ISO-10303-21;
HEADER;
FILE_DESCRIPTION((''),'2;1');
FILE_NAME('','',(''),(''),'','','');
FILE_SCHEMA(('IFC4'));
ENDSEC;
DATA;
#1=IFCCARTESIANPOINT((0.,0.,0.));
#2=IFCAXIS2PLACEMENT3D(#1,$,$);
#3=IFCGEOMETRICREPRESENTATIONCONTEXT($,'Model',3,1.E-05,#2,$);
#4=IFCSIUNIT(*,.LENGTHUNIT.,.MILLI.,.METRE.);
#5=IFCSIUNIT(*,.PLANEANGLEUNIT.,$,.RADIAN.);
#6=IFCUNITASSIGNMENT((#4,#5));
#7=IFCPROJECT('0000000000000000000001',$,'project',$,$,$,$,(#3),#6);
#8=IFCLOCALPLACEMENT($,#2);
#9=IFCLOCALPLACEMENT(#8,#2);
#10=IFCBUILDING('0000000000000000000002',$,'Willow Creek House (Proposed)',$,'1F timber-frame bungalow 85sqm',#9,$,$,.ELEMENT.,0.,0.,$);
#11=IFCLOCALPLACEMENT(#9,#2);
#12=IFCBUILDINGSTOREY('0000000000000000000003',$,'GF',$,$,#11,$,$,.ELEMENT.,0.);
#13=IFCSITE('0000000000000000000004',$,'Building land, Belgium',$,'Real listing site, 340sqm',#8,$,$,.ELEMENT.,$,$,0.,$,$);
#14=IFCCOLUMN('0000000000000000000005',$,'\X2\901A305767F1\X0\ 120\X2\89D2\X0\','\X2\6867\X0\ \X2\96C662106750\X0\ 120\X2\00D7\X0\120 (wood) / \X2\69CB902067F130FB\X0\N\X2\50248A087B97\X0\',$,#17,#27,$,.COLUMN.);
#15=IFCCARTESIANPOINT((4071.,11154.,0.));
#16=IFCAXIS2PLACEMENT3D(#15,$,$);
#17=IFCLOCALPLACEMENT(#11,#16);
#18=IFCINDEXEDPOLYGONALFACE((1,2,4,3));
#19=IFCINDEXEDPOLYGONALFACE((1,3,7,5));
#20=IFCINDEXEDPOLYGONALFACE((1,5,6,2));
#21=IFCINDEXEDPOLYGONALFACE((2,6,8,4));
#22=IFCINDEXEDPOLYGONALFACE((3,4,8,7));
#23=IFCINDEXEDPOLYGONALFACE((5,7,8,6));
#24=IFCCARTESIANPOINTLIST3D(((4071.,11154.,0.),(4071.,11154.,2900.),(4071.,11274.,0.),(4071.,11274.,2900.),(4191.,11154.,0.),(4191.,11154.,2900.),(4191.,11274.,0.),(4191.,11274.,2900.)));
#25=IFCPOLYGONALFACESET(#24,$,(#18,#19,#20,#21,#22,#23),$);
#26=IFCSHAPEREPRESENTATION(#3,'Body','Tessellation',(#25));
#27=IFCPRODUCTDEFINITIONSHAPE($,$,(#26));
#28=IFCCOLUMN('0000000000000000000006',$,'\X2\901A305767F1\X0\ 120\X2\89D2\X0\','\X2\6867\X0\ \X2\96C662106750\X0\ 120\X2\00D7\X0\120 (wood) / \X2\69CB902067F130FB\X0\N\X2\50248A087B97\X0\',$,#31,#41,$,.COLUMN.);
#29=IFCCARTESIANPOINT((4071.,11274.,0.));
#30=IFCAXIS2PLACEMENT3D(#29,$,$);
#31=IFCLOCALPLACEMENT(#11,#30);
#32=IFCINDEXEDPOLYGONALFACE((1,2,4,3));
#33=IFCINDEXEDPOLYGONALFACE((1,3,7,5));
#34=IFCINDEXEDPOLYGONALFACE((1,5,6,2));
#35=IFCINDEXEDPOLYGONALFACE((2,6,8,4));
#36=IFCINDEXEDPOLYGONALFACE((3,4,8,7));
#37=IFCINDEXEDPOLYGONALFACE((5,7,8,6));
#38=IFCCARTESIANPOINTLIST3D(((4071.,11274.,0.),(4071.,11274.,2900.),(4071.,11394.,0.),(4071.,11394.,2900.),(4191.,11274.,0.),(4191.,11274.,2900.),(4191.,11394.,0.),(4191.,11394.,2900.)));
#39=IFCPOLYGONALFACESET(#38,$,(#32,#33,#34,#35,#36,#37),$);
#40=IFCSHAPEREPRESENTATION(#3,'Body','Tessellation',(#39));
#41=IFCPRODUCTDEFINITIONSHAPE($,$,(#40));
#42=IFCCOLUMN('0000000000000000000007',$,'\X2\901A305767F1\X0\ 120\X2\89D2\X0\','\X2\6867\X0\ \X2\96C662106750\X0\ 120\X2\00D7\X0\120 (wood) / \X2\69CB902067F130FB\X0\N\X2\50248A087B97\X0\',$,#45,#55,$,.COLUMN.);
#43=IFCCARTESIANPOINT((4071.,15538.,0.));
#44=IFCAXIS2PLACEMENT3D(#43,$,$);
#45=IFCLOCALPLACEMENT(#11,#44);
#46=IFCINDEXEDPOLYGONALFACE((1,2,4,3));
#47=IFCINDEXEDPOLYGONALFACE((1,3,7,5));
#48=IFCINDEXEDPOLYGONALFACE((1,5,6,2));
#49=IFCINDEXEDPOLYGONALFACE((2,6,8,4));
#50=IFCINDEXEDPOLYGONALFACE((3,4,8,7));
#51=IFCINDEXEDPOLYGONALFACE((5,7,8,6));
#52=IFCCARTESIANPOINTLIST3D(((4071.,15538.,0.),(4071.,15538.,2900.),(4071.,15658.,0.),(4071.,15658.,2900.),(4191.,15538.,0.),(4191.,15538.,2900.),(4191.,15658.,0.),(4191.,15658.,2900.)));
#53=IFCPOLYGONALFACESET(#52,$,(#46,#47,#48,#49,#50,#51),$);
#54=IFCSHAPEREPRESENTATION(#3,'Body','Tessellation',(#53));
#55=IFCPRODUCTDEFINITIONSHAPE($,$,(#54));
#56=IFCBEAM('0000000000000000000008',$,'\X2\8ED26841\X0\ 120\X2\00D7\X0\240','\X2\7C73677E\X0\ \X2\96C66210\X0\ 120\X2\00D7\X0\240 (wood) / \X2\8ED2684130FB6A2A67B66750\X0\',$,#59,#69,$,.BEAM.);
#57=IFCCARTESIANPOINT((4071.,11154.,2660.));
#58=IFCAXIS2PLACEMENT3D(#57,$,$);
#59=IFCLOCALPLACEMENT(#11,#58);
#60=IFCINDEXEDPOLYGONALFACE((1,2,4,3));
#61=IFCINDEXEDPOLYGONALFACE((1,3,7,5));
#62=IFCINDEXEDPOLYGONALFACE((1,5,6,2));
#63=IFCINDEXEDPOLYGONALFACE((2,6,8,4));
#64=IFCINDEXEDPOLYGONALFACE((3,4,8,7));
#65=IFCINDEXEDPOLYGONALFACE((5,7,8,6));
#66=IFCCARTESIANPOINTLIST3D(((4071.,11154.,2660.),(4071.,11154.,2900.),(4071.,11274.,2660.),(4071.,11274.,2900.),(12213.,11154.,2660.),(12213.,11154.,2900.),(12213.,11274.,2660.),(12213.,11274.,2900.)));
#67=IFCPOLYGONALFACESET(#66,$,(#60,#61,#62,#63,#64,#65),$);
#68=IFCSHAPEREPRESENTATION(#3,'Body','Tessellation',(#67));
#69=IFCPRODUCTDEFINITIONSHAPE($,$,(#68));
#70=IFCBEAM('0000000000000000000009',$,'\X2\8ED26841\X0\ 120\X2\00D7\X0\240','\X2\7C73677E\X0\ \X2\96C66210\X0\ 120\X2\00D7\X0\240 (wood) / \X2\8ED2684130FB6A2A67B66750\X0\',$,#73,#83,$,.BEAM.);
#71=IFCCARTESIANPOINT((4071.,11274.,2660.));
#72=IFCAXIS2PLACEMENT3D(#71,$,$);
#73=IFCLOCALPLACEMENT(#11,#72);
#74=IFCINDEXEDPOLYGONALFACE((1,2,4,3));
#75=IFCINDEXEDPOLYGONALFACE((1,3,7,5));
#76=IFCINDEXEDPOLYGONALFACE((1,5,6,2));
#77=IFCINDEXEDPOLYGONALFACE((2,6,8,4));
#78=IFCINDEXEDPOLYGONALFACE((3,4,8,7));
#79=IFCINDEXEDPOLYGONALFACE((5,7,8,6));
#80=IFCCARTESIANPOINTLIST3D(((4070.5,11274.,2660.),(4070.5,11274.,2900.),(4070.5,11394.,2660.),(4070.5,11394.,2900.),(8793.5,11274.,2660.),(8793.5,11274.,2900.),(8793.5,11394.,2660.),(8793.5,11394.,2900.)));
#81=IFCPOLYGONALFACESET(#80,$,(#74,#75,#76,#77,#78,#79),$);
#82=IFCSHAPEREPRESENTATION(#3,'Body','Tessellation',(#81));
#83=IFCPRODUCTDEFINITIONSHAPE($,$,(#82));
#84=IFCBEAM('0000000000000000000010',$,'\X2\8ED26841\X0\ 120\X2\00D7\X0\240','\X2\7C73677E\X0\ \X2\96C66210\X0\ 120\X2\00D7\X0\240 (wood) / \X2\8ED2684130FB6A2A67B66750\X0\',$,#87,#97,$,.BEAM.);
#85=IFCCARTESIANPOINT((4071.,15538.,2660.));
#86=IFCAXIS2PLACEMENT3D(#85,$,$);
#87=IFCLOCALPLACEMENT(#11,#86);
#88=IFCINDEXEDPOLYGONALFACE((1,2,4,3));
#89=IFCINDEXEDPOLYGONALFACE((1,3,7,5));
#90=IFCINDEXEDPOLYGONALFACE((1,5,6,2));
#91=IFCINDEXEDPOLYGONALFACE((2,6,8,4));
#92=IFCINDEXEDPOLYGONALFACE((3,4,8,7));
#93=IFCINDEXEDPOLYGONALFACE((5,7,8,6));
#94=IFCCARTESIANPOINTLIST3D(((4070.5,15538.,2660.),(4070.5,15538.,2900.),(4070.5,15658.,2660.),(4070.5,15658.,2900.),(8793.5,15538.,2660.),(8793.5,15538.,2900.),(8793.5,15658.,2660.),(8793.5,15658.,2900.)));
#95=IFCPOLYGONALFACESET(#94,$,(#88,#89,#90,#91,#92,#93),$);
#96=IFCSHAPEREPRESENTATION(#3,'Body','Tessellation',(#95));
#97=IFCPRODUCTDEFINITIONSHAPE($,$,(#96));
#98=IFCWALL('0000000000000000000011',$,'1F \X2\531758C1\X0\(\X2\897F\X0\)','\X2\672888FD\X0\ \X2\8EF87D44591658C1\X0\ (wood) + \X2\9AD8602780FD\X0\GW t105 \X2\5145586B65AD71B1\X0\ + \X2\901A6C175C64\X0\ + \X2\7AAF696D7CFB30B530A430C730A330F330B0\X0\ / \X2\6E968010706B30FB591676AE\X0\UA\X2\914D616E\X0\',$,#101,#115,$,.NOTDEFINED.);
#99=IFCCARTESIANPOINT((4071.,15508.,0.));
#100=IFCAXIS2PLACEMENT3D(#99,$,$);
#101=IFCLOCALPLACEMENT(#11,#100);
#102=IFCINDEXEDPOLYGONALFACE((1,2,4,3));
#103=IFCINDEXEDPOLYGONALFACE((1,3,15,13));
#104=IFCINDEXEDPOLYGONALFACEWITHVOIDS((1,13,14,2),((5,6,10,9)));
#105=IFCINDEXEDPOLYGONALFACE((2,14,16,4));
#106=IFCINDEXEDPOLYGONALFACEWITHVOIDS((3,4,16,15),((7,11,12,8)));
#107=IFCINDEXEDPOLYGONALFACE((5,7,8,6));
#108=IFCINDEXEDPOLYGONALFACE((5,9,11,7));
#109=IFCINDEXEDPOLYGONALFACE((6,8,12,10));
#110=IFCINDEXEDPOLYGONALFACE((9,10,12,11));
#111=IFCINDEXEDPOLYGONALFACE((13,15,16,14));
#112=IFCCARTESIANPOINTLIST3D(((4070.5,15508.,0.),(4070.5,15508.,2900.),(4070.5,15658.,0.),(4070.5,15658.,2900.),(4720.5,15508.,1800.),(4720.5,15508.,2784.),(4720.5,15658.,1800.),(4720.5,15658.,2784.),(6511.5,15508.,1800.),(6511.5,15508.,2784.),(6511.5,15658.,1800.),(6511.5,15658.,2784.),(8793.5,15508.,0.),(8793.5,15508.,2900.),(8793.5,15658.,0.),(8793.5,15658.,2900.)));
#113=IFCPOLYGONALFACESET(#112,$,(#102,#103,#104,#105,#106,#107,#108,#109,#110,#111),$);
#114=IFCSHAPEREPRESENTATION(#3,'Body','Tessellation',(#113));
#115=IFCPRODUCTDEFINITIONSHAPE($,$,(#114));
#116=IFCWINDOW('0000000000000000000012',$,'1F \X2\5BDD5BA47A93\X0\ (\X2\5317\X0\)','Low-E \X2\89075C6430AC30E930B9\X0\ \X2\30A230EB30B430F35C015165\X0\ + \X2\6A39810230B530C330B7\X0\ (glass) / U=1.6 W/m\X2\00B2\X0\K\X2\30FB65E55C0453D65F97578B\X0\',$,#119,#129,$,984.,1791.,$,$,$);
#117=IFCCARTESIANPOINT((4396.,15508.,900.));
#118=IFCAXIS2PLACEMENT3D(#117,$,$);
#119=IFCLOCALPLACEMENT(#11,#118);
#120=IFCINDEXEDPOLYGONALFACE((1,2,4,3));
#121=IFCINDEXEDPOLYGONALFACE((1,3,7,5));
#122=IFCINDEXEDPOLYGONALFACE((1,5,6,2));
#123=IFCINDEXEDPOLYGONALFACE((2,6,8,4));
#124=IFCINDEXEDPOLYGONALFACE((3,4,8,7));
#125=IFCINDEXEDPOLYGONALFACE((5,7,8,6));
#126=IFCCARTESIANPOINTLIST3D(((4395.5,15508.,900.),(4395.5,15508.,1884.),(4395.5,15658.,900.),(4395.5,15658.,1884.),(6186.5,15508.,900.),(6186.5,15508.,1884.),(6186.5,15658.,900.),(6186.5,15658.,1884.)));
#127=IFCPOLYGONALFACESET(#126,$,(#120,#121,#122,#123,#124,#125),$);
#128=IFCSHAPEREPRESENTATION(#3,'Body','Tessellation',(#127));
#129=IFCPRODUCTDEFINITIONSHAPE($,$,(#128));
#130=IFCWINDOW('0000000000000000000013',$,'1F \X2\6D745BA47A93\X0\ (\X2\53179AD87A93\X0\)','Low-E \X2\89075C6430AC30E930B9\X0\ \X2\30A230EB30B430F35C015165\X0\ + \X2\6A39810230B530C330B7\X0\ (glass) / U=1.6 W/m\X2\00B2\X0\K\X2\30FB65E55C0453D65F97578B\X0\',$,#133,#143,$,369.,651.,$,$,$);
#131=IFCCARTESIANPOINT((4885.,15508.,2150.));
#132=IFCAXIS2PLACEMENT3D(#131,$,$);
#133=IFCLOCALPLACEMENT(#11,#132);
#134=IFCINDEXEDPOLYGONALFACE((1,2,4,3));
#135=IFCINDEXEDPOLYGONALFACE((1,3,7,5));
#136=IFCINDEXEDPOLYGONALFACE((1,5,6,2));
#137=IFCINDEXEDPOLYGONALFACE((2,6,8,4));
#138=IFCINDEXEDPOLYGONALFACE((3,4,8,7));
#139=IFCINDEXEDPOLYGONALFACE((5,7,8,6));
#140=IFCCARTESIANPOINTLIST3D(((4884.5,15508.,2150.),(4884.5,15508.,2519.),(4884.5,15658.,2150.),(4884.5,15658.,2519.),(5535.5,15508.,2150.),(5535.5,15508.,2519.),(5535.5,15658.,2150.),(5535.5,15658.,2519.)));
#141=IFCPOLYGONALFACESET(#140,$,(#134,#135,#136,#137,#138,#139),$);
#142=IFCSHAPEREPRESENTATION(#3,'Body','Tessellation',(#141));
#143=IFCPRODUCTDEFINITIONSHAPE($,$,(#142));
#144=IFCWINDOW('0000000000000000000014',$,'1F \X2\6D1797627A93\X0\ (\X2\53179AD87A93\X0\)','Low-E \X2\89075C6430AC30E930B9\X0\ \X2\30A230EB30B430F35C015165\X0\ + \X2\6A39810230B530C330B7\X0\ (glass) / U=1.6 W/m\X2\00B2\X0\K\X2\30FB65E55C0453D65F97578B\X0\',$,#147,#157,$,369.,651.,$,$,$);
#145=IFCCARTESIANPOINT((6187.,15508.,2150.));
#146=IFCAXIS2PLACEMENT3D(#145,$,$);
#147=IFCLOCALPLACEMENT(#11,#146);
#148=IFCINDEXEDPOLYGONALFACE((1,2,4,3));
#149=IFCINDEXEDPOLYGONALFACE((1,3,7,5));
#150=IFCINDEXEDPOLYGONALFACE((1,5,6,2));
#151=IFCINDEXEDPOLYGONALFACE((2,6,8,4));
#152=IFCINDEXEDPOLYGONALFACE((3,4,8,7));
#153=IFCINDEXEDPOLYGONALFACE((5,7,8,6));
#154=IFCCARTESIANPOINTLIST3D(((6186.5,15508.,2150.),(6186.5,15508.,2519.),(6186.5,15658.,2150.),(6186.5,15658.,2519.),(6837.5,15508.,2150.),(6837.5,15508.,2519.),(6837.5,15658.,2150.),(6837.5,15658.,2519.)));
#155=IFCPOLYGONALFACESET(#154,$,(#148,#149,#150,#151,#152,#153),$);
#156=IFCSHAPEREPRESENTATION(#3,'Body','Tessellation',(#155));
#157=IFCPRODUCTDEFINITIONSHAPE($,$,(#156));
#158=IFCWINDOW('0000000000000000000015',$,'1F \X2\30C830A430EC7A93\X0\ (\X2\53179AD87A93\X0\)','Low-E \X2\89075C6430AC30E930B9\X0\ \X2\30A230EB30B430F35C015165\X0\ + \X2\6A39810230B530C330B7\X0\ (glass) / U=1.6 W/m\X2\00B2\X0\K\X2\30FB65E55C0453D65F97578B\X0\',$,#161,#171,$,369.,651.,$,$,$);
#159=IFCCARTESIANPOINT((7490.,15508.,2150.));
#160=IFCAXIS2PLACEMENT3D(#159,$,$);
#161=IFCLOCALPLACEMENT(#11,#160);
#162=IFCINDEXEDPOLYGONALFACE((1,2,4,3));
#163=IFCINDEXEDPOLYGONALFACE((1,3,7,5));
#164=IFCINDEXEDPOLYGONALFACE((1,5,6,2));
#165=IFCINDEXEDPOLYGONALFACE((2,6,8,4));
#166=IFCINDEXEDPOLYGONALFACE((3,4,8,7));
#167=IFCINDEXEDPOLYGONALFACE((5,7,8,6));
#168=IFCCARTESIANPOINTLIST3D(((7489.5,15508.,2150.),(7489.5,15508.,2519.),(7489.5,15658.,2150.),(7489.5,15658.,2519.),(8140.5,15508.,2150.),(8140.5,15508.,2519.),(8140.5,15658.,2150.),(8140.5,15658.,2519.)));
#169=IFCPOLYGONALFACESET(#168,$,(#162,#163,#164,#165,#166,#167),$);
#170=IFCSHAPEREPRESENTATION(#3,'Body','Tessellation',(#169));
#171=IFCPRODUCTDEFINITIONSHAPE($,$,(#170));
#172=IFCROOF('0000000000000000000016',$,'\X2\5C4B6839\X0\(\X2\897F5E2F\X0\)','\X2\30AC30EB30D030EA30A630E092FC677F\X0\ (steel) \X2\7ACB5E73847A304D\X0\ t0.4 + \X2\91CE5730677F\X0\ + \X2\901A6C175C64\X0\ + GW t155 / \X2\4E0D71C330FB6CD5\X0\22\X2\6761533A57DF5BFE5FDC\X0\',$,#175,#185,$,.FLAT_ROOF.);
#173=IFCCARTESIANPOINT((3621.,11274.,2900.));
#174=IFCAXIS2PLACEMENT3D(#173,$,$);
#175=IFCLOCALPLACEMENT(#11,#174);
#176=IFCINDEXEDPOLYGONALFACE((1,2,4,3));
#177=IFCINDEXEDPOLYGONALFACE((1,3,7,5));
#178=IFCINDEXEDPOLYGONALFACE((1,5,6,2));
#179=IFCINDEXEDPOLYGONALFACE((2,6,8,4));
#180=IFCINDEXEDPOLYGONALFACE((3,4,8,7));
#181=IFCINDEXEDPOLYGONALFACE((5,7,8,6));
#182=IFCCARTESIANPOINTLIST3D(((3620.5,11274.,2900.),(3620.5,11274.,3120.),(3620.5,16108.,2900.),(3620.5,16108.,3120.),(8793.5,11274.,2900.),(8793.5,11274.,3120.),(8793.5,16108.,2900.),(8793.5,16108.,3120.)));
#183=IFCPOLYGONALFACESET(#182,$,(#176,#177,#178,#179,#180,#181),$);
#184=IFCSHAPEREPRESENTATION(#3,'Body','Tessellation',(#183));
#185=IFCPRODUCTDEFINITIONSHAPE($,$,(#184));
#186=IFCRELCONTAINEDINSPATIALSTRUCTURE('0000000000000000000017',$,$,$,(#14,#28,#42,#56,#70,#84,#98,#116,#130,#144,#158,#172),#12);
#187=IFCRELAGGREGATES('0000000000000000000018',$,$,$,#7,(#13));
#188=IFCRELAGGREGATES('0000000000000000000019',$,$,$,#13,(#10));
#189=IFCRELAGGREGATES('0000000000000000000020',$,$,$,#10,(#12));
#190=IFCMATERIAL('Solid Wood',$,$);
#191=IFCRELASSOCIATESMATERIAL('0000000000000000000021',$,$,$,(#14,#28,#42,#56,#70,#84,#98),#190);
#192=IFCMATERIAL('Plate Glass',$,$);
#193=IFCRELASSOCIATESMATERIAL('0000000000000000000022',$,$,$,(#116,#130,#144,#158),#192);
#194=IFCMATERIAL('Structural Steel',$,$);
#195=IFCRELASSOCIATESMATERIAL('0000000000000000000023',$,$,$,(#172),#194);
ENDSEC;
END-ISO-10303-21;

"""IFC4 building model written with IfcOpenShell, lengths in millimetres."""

from ifc_helpers import new_model, si_unit, frame, frame_2d, origin, place, context, project, spatial, rectangle, extrude, material, element, fill, save


model = new_model("IFC4")

# Units and contexts
model_context = context("Model", 3, precision=1e-05, world=origin())
ifc_project = project(units=[si_unit("LENGTHUNIT", "METRE", prefix="MILLI"), si_unit("PLANEANGLEUNIT", "RADIAN")], contexts=[model_context])

# Site, building, storey
site_placement = place(None, origin())
site = spatial("IfcSite", under=ifc_project, at=site_placement, Name="Building land, Belgium", ObjectType="Real listing site, 340sqm", CompositionType="ELEMENT", RefElevation=0.0)
building_placement = place(site_placement, origin())
building = spatial("IfcBuilding", under=site, at=building_placement, Name="Willow Creek House (Proposed)", ObjectType="1F timber-frame bungalow 85sqm", CompositionType="ELEMENT", ElevationOfRefHeight=0.0, ElevationOfTerrain=0.0)
storey_placement = place(building_placement, origin())
storey = spatial("IfcBuildingStorey", under=building, at=storey_placement, Name="GF", CompositionType="ELEMENT", Elevation=0.0)

# Columns
ifc_material_1 = material(Name="Solid Wood")
column_1_placement = place(storey_placement, frame((4071.0, 11154.0, 0.0)))
element("IfcColumn", 1, at=column_1_placement, inside=storey, material=ifc_material_1, Name="通し柱 120角", Description="桧 集成材 120×120 (wood) / 構造柱・N値計算", PredefinedType="COLUMN", context=model_context, shape_type="SweptSolid", body=[
    extrude(rectangle(XDim=120.0, YDim=120.0, at=frame_2d((60.0, 60.0))), frame((4071.0, 11154.0, 0.0)), (0.0, 0.0, 1.0), 2900.0),
])
column_2_placement = place(storey_placement, frame((4071.0, 11274.0, 0.0)))
element("IfcColumn", 2, at=column_2_placement, inside=storey, material=ifc_material_1, Name="通し柱 120角", Description="桧 集成材 120×120 (wood) / 構造柱・N値計算", PredefinedType="COLUMN", context=model_context, shape_type="SweptSolid", body=[
    extrude(rectangle(XDim=120.0, YDim=120.0, at=frame_2d((60.0, 60.0))), frame((4071.0, 11274.0, 0.0)), (0.0, 0.0, 1.0), 2900.0),
])
column_3_placement = place(storey_placement, frame((4071.0, 15538.0, 0.0)))
element("IfcColumn", 3, at=column_3_placement, inside=storey, material=ifc_material_1, Name="通し柱 120角", Description="桧 集成材 120×120 (wood) / 構造柱・N値計算", PredefinedType="COLUMN", context=model_context, shape_type="SweptSolid", body=[
    extrude(rectangle(XDim=120.0, YDim=120.0, at=frame_2d((60.0, 60.0))), frame((4071.0, 15538.0, 0.0)), (0.0, 0.0, 1.0), 2900.0),
])

# Beams
beam_1_placement = place(storey_placement, frame((4071.0, 11154.0, 2660.0)))
element("IfcBeam", 4, at=beam_1_placement, inside=storey, material=ifc_material_1, Name="軒桁 120×240", Description="米松 集成 120×240 (wood) / 軒桁・横架材", PredefinedType="BEAM", context=model_context, shape_type="SweptSolid", body=[
    extrude(rectangle(XDim=8142.0, YDim=120.0, at=frame_2d((4071.0, 60.0))), frame((4071.0, 11154.0, 2660.0)), (0.0, 0.0, 1.0), 240.0),
])
beam_2_placement = place(storey_placement, frame((4071.0, 11274.0, 2660.0)))
element("IfcBeam", 5, at=beam_2_placement, inside=storey, material=ifc_material_1, Name="軒桁 120×240", Description="米松 集成 120×240 (wood) / 軒桁・横架材", PredefinedType="BEAM", context=model_context, shape_type="SweptSolid", body=[
    extrude(rectangle(XDim=4723.0, YDim=120.0, at=frame_2d((2361.0, 60.0))), frame((4071.0, 11274.0, 2660.0)), (0.0, 0.0, 1.0), 240.0),
])
beam_3_placement = place(storey_placement, frame((4071.0, 15538.0, 2660.0)))
element("IfcBeam", 6, at=beam_3_placement, inside=storey, material=ifc_material_1, Name="軒桁 120×240", Description="米松 集成 120×240 (wood) / 軒桁・横架材", PredefinedType="BEAM", context=model_context, shape_type="SweptSolid", body=[
    extrude(rectangle(XDim=4723.0, YDim=120.0, at=frame_2d((2361.0, 60.0))), frame((4071.0, 15538.0, 2660.0)), (0.0, 0.0, 1.0), 240.0),
])

# Wall, openings, windows
wall_1_placement = place(storey_placement, frame((4071.0, 15508.0, 0.0)))
wall_1 = element("IfcWall", 7, at=wall_1_placement, inside=storey, material=ifc_material_1, Name="1F 北壁(西)", Description="木製 軸組外壁 (wood) + 高性能GW t105 充填断熱 + 通気層 + 窯業系サイディング / 準耐火・外皮UA配慮", PredefinedType="NOTDEFINED", context=model_context, shape_type="SweptSolid", body=[
    extrude(rectangle(XDim=4723.0, YDim=150.0, at=frame_2d((2361.0, 75.0))), frame((4071.0, 15508.0, 0.0)), (0.0, 0.0, 1.0), 2900.0),
])
opening_1_placement = place(storey_placement, frame((4396.0, 15508.0, 900.0)))
opening_1 = element("IfcOpeningElement", 8, at=opening_1_placement, cuts=wall_1, PredefinedType="NOTDEFINED", context=model_context, shape_type="SweptSolid", body=[
    extrude(rectangle(XDim=1791.0, YDim=150.0, at=frame_2d((895.0, 75.0))), frame((4396.0, 15508.0, 900.0)), (0.0, 0.0, 1.0), 984.0),
])
opening_2_placement = place(storey_placement, frame((4885.0, 15508.0, 2150.0)))
opening_2 = element("IfcOpeningElement", 9, at=opening_2_placement, cuts=wall_1, PredefinedType="NOTDEFINED", context=model_context, shape_type="SweptSolid", body=[
    extrude(rectangle(XDim=651.0, YDim=150.0, at=frame_2d((325.0, 75.0))), frame((4885.0, 15508.0, 2150.0)), (0.0, 0.0, 1.0), 369.0),
])
opening_3_placement = place(storey_placement, frame((6187.0, 15508.0, 2150.0)))
opening_3 = element("IfcOpeningElement", 10, at=opening_3_placement, cuts=wall_1, PredefinedType="NOTDEFINED", context=model_context, shape_type="SweptSolid", body=[
    extrude(rectangle(XDim=651.0, YDim=150.0, at=frame_2d((325.0, 75.0))), frame((6187.0, 15508.0, 2150.0)), (0.0, 0.0, 1.0), 369.0),
])
opening_4_placement = place(storey_placement, frame((7490.0, 15508.0, 2150.0)))
opening_4 = element("IfcOpeningElement", 11, at=opening_4_placement, cuts=wall_1, PredefinedType="NOTDEFINED", context=model_context, shape_type="SweptSolid", body=[
    extrude(rectangle(XDim=651.0, YDim=150.0, at=frame_2d((325.0, 75.0))), frame((7490.0, 15508.0, 2150.0)), (0.0, 0.0, 1.0), 369.0),
])
ifc_material_2 = material(Name="Plate Glass")
window_1_placement = place(storey_placement, frame((4396.0, 15508.0, 900.0)))
window_1 = element("IfcWindow", 12, at=window_1_placement, inside=storey, material=ifc_material_2, Name="1F 寝室窓 (北)", Description="Low-E 複層ガラス アルゴン封入 + 樹脂サッシ (glass) / U=1.6 W/m²K・日射取得型", OverallHeight=984.0, OverallWidth=1791.0, context=model_context, shape_type="SweptSolid", body=[
    extrude(rectangle(XDim=1791.0, YDim=150.0, at=frame_2d((895.0, 75.0))), frame((4396.0, 15508.0, 900.0)), (0.0, 0.0, 1.0), 984.0),
])
fill(opening_1, window_1)
window_2_placement = place(storey_placement, frame((4885.0, 15508.0, 2150.0)))
window_2 = element("IfcWindow", 13, at=window_2_placement, inside=storey, material=ifc_material_2, Name="1F 浴室窓 (北高窓)", Description="Low-E 複層ガラス アルゴン封入 + 樹脂サッシ (glass) / U=1.6 W/m²K・日射取得型", OverallHeight=369.0, OverallWidth=651.0, context=model_context, shape_type="SweptSolid", body=[
    extrude(rectangle(XDim=651.0, YDim=150.0, at=frame_2d((325.0, 75.0))), frame((4885.0, 15508.0, 2150.0)), (0.0, 0.0, 1.0), 369.0),
])
fill(opening_2, window_2)
window_3_placement = place(storey_placement, frame((6187.0, 15508.0, 2150.0)))
window_3 = element("IfcWindow", 14, at=window_3_placement, inside=storey, material=ifc_material_2, Name="1F 洗面窓 (北高窓)", Description="Low-E 複層ガラス アルゴン封入 + 樹脂サッシ (glass) / U=1.6 W/m²K・日射取得型", OverallHeight=369.0, OverallWidth=651.0, context=model_context, shape_type="SweptSolid", body=[
    extrude(rectangle(XDim=651.0, YDim=150.0, at=frame_2d((325.0, 75.0))), frame((6187.0, 15508.0, 2150.0)), (0.0, 0.0, 1.0), 369.0),
])
fill(opening_3, window_3)
window_4_placement = place(storey_placement, frame((7490.0, 15508.0, 2150.0)))
window_4 = element("IfcWindow", 15, at=window_4_placement, inside=storey, material=ifc_material_2, Name="1F トイレ窓 (北高窓)", Description="Low-E 複層ガラス アルゴン封入 + 樹脂サッシ (glass) / U=1.6 W/m²K・日射取得型", OverallHeight=369.0, OverallWidth=651.0, context=model_context, shape_type="SweptSolid", body=[
    extrude(rectangle(XDim=651.0, YDim=150.0, at=frame_2d((325.0, 75.0))), frame((7490.0, 15508.0, 2150.0)), (0.0, 0.0, 1.0), 369.0),
])
fill(opening_4, window_4)

# Roof
ifc_material_3 = material(Name="Structural Steel")
roof_placement = place(storey_placement, frame((3621.0, 11274.0, 2900.0)))
element("IfcRoof", 16, at=roof_placement, inside=storey, material=ifc_material_3, Name="屋根(西帯)", Description="ガルバリウム鋼板 (steel) 立平葺き t0.4 + 野地板 + 通気層 + GW t155 / 不燃・法22条区域対応", PredefinedType="FLAT_ROOF", context=model_context, shape_type="SweptSolid", body=[
    extrude(rectangle(XDim=5173.0, YDim=4834.0, at=frame_2d((2586.0, 2417.0))), frame((3621.0, 11274.0, 2900.0)), (0.0, 0.0, 1.0), 220.0),
])

save(model, "model.ifc")
